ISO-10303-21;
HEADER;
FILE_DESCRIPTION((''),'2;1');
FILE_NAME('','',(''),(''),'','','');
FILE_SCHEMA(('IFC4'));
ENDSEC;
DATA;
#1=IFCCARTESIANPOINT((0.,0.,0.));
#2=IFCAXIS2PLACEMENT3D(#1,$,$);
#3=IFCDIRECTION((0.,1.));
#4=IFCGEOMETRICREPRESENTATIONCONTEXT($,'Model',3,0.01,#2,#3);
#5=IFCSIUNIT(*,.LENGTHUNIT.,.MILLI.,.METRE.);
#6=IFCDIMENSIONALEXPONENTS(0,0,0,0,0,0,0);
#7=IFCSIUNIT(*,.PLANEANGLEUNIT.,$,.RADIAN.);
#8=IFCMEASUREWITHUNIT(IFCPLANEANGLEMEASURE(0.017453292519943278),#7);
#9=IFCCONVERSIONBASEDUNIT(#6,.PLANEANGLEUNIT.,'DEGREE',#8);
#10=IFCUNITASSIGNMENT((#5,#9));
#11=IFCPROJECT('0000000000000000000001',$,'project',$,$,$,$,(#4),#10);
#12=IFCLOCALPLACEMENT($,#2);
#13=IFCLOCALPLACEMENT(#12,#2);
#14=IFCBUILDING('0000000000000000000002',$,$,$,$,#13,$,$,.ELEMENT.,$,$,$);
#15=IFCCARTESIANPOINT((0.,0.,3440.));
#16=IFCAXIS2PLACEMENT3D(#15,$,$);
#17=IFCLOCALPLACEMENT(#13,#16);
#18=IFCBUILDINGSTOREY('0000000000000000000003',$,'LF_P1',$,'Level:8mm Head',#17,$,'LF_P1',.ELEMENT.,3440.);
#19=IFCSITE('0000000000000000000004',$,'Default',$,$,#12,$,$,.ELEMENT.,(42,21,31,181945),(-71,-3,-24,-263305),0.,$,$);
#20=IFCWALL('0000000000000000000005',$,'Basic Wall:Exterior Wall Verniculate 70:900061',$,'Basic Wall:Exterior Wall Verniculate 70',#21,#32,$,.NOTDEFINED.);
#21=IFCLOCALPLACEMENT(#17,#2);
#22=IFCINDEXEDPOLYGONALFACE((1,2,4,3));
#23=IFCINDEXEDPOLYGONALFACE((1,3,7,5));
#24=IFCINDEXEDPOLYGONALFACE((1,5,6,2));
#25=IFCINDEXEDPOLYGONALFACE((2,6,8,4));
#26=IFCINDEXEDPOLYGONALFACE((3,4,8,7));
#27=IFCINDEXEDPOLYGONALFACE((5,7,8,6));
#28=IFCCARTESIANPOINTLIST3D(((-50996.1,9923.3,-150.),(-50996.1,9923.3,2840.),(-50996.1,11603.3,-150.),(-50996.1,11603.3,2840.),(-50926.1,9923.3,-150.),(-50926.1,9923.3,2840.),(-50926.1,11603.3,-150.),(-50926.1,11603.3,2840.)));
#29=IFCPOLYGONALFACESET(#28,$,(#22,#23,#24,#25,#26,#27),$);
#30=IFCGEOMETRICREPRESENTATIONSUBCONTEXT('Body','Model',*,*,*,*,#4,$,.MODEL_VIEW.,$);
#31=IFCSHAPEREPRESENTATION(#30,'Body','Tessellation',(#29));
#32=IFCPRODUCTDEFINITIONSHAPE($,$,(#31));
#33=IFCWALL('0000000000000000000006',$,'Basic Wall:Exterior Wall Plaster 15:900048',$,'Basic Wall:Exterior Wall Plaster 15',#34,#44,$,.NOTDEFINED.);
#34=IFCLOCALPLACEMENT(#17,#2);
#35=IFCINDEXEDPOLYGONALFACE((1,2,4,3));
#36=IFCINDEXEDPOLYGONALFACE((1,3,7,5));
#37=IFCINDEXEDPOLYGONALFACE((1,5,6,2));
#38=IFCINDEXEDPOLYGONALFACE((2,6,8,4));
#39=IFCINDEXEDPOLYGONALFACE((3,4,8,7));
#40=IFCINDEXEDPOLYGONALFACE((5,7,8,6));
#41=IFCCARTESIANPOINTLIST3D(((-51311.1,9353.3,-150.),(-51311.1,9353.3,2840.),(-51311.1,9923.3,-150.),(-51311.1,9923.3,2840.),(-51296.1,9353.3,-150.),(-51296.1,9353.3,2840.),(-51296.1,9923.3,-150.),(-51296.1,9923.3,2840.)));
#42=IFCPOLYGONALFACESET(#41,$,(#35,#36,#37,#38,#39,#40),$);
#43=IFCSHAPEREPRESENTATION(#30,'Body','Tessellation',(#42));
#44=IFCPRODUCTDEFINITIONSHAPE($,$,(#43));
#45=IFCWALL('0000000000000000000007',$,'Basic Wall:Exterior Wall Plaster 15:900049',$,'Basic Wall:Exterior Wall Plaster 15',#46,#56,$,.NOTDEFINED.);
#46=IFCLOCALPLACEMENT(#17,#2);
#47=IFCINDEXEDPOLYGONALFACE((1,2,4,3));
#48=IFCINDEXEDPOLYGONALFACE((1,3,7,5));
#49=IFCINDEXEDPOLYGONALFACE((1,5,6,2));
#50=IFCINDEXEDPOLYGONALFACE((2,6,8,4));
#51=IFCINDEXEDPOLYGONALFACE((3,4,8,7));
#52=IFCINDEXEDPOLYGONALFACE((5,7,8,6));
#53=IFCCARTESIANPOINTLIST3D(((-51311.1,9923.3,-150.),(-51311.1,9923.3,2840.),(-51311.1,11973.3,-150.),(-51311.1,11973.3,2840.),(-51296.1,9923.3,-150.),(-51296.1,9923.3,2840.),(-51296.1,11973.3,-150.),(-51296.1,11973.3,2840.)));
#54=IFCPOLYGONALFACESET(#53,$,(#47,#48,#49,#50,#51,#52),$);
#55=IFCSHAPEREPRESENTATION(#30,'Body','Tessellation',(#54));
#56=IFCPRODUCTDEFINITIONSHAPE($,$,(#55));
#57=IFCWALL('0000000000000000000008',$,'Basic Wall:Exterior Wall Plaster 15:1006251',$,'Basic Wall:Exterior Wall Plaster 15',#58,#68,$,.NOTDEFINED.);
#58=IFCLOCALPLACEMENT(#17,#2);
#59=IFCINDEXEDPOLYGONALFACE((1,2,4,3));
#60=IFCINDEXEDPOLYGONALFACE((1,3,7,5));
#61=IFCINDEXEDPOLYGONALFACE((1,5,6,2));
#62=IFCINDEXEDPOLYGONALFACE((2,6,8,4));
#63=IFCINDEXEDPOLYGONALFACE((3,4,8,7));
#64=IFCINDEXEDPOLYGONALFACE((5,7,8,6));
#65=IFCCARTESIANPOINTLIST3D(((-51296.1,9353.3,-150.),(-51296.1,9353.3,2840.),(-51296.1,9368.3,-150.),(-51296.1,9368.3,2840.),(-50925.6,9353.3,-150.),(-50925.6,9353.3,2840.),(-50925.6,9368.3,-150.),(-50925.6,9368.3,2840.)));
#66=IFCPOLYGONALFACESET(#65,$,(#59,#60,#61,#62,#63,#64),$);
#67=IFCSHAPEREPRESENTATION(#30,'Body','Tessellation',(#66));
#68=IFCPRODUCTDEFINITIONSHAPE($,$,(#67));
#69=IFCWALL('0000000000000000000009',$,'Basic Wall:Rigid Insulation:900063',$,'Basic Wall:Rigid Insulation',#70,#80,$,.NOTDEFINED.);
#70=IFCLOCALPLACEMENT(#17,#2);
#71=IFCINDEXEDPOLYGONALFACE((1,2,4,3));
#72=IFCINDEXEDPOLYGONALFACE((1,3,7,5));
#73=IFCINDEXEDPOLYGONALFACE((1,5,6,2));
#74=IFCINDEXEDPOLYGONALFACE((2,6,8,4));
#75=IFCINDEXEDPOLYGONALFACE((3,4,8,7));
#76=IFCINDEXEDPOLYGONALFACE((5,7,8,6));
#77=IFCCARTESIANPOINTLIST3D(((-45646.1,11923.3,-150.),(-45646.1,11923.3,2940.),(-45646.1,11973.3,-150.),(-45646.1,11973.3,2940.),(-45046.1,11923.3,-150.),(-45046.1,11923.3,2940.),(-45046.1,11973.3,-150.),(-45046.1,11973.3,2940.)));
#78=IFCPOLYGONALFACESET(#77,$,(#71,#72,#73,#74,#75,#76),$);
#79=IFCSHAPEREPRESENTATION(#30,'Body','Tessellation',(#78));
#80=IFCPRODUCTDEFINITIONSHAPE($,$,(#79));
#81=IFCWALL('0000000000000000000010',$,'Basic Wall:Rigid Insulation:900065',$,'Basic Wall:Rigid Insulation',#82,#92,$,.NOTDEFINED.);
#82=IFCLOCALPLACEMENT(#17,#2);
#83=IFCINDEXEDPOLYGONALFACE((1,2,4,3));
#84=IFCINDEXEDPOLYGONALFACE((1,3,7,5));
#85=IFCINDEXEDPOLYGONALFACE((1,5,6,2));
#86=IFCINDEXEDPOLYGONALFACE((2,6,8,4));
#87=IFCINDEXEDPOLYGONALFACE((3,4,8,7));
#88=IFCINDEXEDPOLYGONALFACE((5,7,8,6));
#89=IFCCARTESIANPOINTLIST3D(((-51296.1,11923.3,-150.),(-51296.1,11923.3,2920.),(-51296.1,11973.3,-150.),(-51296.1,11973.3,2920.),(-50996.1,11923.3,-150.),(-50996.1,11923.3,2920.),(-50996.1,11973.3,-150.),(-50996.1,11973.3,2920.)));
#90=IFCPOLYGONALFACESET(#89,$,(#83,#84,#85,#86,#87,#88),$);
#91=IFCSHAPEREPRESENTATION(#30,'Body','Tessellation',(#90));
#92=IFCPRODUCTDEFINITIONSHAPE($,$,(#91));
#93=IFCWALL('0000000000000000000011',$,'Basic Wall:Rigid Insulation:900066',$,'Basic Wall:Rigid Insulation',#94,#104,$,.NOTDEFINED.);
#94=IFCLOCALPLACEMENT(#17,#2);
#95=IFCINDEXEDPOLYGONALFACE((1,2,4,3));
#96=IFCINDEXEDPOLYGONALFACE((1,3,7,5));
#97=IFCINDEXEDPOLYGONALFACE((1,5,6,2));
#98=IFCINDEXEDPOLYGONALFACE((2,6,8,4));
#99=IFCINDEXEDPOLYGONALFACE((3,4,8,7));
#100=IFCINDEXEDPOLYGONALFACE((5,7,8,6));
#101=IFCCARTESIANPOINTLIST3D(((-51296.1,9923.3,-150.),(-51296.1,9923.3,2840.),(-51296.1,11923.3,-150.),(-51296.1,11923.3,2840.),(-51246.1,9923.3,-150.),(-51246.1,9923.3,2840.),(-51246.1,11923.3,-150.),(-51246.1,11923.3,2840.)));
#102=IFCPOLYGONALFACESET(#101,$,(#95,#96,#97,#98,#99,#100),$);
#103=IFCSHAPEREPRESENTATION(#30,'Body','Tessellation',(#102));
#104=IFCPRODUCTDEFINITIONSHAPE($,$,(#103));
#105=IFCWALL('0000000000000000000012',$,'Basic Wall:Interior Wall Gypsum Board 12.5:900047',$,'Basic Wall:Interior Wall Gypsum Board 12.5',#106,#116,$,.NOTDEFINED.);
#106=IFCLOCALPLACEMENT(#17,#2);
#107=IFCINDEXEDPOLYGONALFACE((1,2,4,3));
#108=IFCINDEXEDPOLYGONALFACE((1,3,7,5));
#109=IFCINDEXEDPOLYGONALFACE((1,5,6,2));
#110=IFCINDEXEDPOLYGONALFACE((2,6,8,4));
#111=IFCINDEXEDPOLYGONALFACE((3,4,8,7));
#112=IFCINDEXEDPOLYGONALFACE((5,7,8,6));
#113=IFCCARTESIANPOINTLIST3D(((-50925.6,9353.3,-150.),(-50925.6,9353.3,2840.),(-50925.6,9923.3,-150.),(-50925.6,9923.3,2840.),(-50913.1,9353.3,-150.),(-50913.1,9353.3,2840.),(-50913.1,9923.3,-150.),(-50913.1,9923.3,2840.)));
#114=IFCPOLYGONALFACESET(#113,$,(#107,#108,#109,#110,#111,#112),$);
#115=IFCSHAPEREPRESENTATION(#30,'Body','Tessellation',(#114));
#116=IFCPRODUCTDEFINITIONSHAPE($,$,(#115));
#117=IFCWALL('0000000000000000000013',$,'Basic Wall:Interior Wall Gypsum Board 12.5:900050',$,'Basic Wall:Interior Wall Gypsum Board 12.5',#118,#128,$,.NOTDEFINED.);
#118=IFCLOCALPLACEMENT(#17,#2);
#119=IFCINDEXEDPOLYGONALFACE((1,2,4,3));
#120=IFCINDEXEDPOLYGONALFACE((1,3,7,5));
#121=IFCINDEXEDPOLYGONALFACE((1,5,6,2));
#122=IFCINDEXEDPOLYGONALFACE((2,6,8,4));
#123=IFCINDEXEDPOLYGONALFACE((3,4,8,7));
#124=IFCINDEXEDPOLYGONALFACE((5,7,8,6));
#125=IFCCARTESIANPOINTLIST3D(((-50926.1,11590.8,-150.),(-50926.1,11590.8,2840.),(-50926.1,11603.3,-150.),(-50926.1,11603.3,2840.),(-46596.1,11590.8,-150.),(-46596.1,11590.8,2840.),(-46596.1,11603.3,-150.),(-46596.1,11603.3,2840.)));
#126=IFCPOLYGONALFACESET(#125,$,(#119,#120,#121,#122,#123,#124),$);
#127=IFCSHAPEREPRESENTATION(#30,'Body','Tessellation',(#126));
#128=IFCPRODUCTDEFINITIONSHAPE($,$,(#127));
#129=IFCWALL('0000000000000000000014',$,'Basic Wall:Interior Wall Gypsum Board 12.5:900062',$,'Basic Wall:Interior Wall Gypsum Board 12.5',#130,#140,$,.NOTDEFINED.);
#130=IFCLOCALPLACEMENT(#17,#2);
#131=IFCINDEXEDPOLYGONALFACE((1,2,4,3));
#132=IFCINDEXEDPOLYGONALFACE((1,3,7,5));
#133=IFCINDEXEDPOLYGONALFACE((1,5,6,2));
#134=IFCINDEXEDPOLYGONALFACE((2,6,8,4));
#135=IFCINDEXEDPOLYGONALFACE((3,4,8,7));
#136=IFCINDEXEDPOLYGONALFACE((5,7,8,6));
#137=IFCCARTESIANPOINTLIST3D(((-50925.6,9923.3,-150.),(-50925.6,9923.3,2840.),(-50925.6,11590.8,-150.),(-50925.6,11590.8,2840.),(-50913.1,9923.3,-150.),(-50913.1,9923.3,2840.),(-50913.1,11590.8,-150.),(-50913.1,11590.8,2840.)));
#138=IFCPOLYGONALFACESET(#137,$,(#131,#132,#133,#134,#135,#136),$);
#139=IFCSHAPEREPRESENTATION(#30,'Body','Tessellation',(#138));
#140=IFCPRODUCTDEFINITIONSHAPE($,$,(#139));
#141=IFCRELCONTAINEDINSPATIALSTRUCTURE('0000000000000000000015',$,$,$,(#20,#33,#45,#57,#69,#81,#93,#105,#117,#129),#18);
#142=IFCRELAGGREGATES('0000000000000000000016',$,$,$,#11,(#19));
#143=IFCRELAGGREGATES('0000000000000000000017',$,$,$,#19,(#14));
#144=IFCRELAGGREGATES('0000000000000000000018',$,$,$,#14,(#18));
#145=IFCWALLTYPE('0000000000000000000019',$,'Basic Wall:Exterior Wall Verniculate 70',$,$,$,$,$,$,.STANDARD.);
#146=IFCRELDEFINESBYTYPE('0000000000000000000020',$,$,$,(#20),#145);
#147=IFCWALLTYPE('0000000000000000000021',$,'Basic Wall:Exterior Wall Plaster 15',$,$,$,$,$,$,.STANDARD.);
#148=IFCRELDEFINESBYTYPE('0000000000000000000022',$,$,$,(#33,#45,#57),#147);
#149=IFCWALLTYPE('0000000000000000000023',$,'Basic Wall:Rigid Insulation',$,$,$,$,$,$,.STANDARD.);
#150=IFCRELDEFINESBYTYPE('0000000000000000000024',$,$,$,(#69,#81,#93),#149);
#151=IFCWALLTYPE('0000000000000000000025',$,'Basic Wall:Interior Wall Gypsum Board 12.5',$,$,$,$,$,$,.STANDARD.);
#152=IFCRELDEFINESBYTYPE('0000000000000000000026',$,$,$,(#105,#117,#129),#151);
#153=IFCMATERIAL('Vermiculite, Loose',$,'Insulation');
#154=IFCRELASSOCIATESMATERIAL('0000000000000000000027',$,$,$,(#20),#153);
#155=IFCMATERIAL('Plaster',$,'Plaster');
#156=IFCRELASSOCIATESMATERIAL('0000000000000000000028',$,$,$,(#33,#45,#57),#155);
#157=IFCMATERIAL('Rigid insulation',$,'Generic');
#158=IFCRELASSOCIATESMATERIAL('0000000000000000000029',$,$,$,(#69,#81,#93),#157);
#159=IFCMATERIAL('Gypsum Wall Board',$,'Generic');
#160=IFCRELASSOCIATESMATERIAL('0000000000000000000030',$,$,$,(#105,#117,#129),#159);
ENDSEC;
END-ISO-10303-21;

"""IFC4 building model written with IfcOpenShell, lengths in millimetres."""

from ifc_helpers import new_model, entity, si_unit, converted_unit, direction, frame, origin, place, context, subcontext, project, spatial, indexed_curve, outline, extrude, material, type_object, element, save


model = new_model("IFC4")

# Units and contexts
model_context = context("Model", 3, precision=0.01, world=origin(), true_north=direction((0.0, 1.0)))
body_context = subcontext(model_context, "Body", "Model", "MODEL_VIEW")
ifc_project = project(units=[si_unit("LENGTHUNIT", "METRE", prefix="MILLI"), converted_unit("PLANEANGLEUNIT", "DEGREE", entity("IfcPlaneAngleMeasure", 0.017453292519943278), si_unit("PLANEANGLEUNIT", "RADIAN"), dimensions=[0, 0, 0, 0, 0, 0, 0])], contexts=[model_context])

# Site, building, storey
site_placement = place(None, origin())
site = spatial("IfcSite", under=ifc_project, at=site_placement, Name="Default", CompositionType="ELEMENT", RefLatitude=(42, 21, 31, 181945), RefLongitude=(-71, -3, -24, -263305), RefElevation=0.0)
building_placement = place(site_placement, origin())
building = spatial("IfcBuilding", under=site, at=building_placement, CompositionType="ELEMENT")
storey_placement = place(building_placement, frame((0.0, 0.0, 3440.0)))
storey = spatial("IfcBuildingStorey", under=building, at=storey_placement, Name="LF_P1", ObjectType="Level:8mm Head", LongName="LF_P1", CompositionType="ELEMENT", Elevation=3440.0)

# Walls
ifc_material_1 = material(Name="Rigid insulation", Category="Generic")
ifc_material_2 = material(Name="Vermiculite, Loose", Category="Insulation")
wall_type_1 = type_object("IfcWallType", Name="Basic Wall:Exterior Wall Verniculate 70", PredefinedType="STANDARD")
wall_1_placement = place(storey_placement, frame((-50961.1, 11603.3, -150.0), z_axis=(0.0, 0.0, 1.0), x_axis=(0.0, -1.0, 0.0)))
element("IfcWall", 1, at=wall_1_placement, inside=storey, type_object=wall_type_1, material=ifc_material_2, Name="Basic Wall:Exterior Wall Verniculate 70:900061", ObjectType="Basic Wall:Exterior Wall Verniculate 70", PredefinedType="NOTDEFINED", context=body_context, shape_type="SweptSolid", body=[
    extrude(outline(indexed_curve([(1680.0, 35.0), (0.0, 35.0), (0.0, -35.0), (1680.0, -35.0), (1680.0, 35.0)], self_intersect=False)), origin(), (0.0, 0.0, 1.0), 2990.0),
])
ifc_material_3 = material(Name="Plaster", Category="Plaster")
wall_type_2 = type_object("IfcWallType", Name="Basic Wall:Exterior Wall Plaster 15", PredefinedType="STANDARD")
wall_2_placement = place(storey_placement, frame((-51303.6, 9923.3, -150.0), z_axis=(0.0, 0.0, 1.0), x_axis=(0.0, -1.0, 0.0)))
element("IfcWall", 2, at=wall_2_placement, inside=storey, type_object=wall_type_2, material=ifc_material_3, Name="Basic Wall:Exterior Wall Plaster 15:900048", ObjectType="Basic Wall:Exterior Wall Plaster 15", PredefinedType="NOTDEFINED", context=body_context, shape_type="SweptSolid", body=[
    extrude(outline(indexed_curve([(570.0, 7.5), (0.0, 7.5), (0.0, -7.5), (570.0, -7.5), (570.0, 7.5)], self_intersect=False)), origin(), (0.0, 0.0, 1.0), 2990.0),
])
wall_3_placement = place(storey_placement, frame((-51303.6, 9923.3, -150.0), z_axis=(0.0, 0.0, 1.0), x_axis=(0.0, 1.0, 0.0)))
element("IfcWall", 3, at=wall_3_placement, inside=storey, type_object=wall_type_2, material=ifc_material_3, Name="Basic Wall:Exterior Wall Plaster 15:900049", ObjectType="Basic Wall:Exterior Wall Plaster 15", PredefinedType="NOTDEFINED", context=body_context, shape_type="SweptSolid", body=[
    extrude(outline(indexed_curve([(2050.0, 7.5), (0.0, 7.5), (0.0, -7.5), (2050.0, -7.5), (2050.0, 7.5)], self_intersect=False)), origin(), (0.0, 0.0, 1.0), 2990.0),
])
wall_4_placement = place(storey_placement, frame((-51296.1, 9360.8, -150.0)))
element("IfcWall", 4, at=wall_4_placement, inside=storey, type_object=wall_type_2, material=ifc_material_3, Name="Basic Wall:Exterior Wall Plaster 15:1006251", ObjectType="Basic Wall:Exterior Wall Plaster 15", PredefinedType="NOTDEFINED", context=body_context, shape_type="SweptSolid", body=[
    extrude(outline(indexed_curve([(370.5, 7.5), (0.0, 7.5), (0.0, -7.5), (370.5, -7.5), (370.5, 7.5)], self_intersect=False)), origin(), (0.0, 0.0, 1.0), 2990.0),
])
wall_type_3 = type_object("IfcWallType", Name="Basic Wall:Rigid Insulation", PredefinedType="STANDARD")
wall_5_placement = place(storey_placement, frame((-45646.1, 11948.3, -150.0)))
element("IfcWall", 5, at=wall_5_placement, inside=storey, type_object=wall_type_3, material=ifc_material_1, Name="Basic Wall:Rigid Insulation:900063", ObjectType="Basic Wall:Rigid Insulation", PredefinedType="NOTDEFINED", context=body_context, shape_type="SweptSolid", body=[
    extrude(outline(indexed_curve([(600.0, 25.0), (0.0, 25.0), (0.0, -25.0), (600.0, -25.0), (600.0, 25.0)], self_intersect=False)), origin(), (0.0, 0.0, 1.0), 3090.0),
])
wall_6_placement = place(storey_placement, frame((-50996.1, 11948.3, -150.0), z_axis=(0.0, 0.0, 1.0), x_axis=(-1.0, 0.0, 0.0)))
element("IfcWall", 6, at=wall_6_placement, inside=storey, type_object=wall_type_3, material=ifc_material_1, Name="Basic Wall:Rigid Insulation:900065", ObjectType="Basic Wall:Rigid Insulation", PredefinedType="NOTDEFINED", context=body_context, shape_type="SweptSolid", body=[
    extrude(outline(indexed_curve([(300.0, 25.0), (0.0, 25.0), (0.0, -25.0), (300.0, -25.0), (300.0, 25.0)], self_intersect=False)), origin(), (0.0, 0.0, 1.0), 3070.0),
])
wall_7_placement = place(storey_placement, frame((-51271.1, 11923.3, -150.0), z_axis=(0.0, 0.0, 1.0), x_axis=(0.0, -1.0, 0.0)))
element("IfcWall", 7, at=wall_7_placement, inside=storey, type_object=wall_type_3, material=ifc_material_1, Name="Basic Wall:Rigid Insulation:900066", ObjectType="Basic Wall:Rigid Insulation", PredefinedType="NOTDEFINED", context=body_context, shape_type="SweptSolid", body=[
    extrude(outline(indexed_curve([(2000.0, 25.0), (0.0, 25.0), (0.0, -25.0), (2000.0, -25.0), (2000.0, 25.0)], self_intersect=False)), origin(), (0.0, 0.0, 1.0), 2990.0),
])
ifc_material_4 = material(Name="Gypsum Wall Board", Category="Generic")
wall_type_4 = type_object("IfcWallType", Name="Basic Wall:Interior Wall Gypsum Board 12.5", PredefinedType="STANDARD")
wall_8_placement = place(storey_placement, frame((-50919.4, 9923.3, -150.0), z_axis=(0.0, 0.0, 1.0), x_axis=(0.0, -1.0, 0.0)))
element("IfcWall", 8, at=wall_8_placement, inside=storey, type_object=wall_type_4, material=ifc_material_4, Name="Basic Wall:Interior Wall Gypsum Board 12.5:900047", ObjectType="Basic Wall:Interior Wall Gypsum Board 12.5", PredefinedType="NOTDEFINED", context=body_context, shape_type="SweptSolid", body=[
    extrude(outline(indexed_curve([(570.0, 6.3), (0.0, 6.3), (0.0, -6.3), (570.0, -6.3), (570.0, 6.3)], self_intersect=False)), origin(), (0.0, 0.0, 1.0), 2990.0),
])
wall_9_placement = place(storey_placement, frame((-50926.1, 11597.1, -150.0)))
element("IfcWall", 9, at=wall_9_placement, inside=storey, type_object=wall_type_4, material=ifc_material_4, Name="Basic Wall:Interior Wall Gypsum Board 12.5:900050", ObjectType="Basic Wall:Interior Wall Gypsum Board 12.5", PredefinedType="NOTDEFINED", context=body_context, shape_type="SweptSolid", body=[
    extrude(outline(indexed_curve([(4330.0, 6.2), (0.0, 6.3), (0.0, -6.3), (4330.0, -6.3), (4330.0, 6.2)], self_intersect=False)), origin(), (0.0, 0.0, 1.0), 2990.0),
])
wall_10_placement = place(storey_placement, frame((-50919.4, 11590.8, -150.0), z_axis=(0.0, 0.0, 1.0), x_axis=(0.0, -1.0, 0.0)))
element("IfcWall", 10, at=wall_10_placement, inside=storey, type_object=wall_type_4, material=ifc_material_4, Name="Basic Wall:Interior Wall Gypsum Board 12.5:900062", ObjectType="Basic Wall:Interior Wall Gypsum Board 12.5", PredefinedType="NOTDEFINED", context=body_context, shape_type="SweptSolid", body=[
    extrude(outline(indexed_curve([(1667.5, 6.3), (0.0, 6.3), (0.0, -6.3), (1667.5, -6.3), (1667.5, 6.3)], self_intersect=False)), origin(), (0.0, 0.0, 1.0), 2990.0),
])

save(model, "model.ifc")
